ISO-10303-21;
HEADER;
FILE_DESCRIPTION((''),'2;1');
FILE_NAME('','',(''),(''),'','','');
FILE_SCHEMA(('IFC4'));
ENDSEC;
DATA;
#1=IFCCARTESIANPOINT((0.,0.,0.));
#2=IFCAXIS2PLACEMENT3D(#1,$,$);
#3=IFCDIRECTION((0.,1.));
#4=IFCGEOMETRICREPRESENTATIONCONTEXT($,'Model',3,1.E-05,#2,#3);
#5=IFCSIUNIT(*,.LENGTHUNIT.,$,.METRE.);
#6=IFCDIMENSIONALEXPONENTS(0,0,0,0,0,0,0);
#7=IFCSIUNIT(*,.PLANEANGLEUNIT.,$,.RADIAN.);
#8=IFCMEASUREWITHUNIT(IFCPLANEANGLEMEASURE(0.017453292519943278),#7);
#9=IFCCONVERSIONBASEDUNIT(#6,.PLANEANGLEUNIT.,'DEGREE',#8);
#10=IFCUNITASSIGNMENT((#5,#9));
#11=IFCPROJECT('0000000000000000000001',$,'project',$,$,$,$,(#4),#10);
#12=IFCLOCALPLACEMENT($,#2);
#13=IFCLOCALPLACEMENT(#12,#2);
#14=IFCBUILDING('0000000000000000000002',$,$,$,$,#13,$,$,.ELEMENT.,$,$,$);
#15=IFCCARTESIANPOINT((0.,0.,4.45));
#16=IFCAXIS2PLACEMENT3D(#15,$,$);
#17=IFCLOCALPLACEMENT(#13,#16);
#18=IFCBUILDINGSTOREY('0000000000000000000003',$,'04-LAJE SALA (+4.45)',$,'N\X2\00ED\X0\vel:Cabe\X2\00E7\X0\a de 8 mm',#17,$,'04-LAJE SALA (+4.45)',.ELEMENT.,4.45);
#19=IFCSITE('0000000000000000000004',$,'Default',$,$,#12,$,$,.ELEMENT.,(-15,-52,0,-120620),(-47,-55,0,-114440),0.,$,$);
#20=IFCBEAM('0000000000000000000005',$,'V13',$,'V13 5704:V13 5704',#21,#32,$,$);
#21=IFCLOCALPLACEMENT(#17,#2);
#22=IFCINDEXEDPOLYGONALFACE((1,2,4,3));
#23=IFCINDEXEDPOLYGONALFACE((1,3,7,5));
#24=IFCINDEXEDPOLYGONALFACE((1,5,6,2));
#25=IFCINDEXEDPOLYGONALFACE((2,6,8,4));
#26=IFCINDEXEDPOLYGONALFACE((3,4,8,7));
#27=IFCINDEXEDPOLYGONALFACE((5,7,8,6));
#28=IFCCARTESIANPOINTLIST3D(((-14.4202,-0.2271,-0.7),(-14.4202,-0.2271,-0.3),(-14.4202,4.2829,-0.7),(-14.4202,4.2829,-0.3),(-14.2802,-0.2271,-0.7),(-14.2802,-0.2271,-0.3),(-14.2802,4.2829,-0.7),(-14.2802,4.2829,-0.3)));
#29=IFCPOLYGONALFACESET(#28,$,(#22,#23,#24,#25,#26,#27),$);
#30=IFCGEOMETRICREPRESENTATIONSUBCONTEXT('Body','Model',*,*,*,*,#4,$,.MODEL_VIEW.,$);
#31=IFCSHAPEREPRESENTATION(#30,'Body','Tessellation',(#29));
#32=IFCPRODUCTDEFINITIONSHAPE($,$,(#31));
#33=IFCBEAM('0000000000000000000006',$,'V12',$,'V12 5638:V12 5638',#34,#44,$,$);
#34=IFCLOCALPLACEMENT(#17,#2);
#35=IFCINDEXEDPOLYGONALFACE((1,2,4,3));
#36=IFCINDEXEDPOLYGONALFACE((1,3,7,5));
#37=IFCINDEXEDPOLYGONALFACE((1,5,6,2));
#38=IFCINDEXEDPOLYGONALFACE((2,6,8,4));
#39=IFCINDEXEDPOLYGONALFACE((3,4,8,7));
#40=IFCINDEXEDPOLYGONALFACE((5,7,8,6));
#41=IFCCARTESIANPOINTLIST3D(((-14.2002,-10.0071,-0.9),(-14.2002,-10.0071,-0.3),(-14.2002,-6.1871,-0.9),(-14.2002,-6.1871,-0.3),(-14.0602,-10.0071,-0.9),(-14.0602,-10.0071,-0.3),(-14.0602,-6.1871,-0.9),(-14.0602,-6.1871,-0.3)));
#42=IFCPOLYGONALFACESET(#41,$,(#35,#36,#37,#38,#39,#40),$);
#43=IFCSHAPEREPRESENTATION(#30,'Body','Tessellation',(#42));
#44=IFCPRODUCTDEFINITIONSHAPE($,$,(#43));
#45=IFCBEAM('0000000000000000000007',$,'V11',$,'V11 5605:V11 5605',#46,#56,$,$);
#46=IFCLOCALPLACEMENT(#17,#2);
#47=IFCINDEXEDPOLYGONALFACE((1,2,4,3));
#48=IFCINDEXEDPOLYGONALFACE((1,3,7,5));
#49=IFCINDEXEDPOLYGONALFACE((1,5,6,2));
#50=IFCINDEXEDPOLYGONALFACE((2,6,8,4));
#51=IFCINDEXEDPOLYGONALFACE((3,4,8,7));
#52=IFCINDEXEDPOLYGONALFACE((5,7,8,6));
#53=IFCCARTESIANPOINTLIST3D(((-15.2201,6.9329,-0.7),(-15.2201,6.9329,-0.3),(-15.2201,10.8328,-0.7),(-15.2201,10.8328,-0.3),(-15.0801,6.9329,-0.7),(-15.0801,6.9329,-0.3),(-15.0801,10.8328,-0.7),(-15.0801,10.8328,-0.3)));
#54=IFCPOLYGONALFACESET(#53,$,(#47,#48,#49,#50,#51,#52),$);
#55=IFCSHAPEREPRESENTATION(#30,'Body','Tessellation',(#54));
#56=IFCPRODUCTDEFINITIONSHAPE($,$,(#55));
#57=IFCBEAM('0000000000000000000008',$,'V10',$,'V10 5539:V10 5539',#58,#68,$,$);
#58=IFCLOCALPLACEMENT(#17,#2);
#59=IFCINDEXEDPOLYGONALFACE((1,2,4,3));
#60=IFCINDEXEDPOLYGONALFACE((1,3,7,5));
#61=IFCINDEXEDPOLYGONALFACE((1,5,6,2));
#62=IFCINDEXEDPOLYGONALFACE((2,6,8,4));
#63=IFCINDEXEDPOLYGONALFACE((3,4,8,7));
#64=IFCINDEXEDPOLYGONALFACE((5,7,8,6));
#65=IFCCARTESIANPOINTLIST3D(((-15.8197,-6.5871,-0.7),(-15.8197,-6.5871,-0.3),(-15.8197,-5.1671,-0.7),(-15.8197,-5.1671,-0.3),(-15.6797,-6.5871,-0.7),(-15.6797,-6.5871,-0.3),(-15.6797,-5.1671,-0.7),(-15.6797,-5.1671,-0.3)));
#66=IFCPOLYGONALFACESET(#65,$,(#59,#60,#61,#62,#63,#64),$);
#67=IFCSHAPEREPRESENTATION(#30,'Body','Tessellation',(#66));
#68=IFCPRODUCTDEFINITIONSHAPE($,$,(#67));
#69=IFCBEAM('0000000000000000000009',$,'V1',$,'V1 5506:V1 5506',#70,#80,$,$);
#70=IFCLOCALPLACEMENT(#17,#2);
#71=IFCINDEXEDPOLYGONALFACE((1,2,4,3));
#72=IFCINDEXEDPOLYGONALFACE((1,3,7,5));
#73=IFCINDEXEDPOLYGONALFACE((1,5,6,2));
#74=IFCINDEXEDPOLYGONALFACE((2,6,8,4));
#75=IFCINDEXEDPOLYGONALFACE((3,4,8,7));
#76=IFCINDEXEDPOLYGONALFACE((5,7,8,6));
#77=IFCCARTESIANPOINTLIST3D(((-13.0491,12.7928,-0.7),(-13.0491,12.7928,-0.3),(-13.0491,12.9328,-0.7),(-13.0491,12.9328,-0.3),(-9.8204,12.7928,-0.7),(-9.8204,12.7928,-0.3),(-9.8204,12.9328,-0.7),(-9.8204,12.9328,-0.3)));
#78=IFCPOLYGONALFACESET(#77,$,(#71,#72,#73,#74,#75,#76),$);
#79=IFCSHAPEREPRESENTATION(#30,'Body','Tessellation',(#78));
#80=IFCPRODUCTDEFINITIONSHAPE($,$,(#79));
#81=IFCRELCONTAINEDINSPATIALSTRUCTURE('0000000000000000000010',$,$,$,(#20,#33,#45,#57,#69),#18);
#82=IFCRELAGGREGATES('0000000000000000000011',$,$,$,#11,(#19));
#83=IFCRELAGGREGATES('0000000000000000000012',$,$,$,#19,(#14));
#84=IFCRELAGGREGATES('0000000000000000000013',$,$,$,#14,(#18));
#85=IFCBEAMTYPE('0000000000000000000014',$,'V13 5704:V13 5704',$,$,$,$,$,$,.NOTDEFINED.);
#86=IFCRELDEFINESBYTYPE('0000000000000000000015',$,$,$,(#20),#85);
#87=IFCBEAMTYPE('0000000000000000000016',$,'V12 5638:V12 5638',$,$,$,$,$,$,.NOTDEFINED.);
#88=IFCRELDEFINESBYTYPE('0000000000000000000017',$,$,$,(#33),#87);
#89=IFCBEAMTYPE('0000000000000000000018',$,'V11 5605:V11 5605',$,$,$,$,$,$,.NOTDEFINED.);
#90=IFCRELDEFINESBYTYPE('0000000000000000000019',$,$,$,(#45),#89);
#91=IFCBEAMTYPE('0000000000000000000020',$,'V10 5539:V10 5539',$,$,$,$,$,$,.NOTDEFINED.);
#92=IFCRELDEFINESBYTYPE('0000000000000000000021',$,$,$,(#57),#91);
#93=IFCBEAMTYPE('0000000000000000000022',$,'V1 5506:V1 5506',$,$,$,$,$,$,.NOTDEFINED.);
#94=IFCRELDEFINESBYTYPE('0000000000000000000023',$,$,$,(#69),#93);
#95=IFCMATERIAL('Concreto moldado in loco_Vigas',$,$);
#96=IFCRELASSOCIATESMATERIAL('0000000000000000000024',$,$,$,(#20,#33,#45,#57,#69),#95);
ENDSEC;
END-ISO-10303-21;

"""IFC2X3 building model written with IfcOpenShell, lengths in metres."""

from ifc_helpers import new_model, entity, si_unit, converted_unit, direction, frame, frame_2d, origin, place, context, subcontext, project, spatial, rectangle, extrude, material, type_object, element, save


model = new_model("IFC2X3")

# Units and contexts
model_context = context("Model", 3, precision=1e-05, world=origin(), true_north=direction((0.0, 1.0)))
body_context = subcontext(model_context, "Body", "Model", "MODEL_VIEW")
ifc_project = project(units=[si_unit("LENGTHUNIT", "METRE"), converted_unit("PLANEANGLEUNIT", "DEGREE", entity("IfcPlaneAngleMeasure", 0.017453292519943278), si_unit("PLANEANGLEUNIT", "RADIAN"), dimensions=[0, 0, 0, 0, 0, 0, 0])], contexts=[model_context])

# Site, building, storey
site_placement = place(None, origin())
site = spatial("IfcSite", under=ifc_project, at=site_placement, Name="Default", CompositionType="ELEMENT", RefLatitude=(-15, -52, 0, -120620), RefLongitude=(-47, -55, 0, -114440), RefElevation=0.0)
building_placement = place(site_placement, origin())
building = spatial("IfcBuilding", under=site, at=building_placement, CompositionType="ELEMENT")
storey_placement = place(building_placement, frame((0.0, 0.0, 4.45)))
storey = spatial("IfcBuildingStorey", under=building, at=storey_placement, Name="04-LAJE SALA (+4.45)", ObjectType="Nível:Cabeça de 8 mm", LongName="04-LAJE SALA (+4.45)", CompositionType="ELEMENT", Elevation=4.45)

# Beams
ifc_material_1 = material(Name="Concreto moldado in loco_Vigas")
beam_type_1 = type_object("IfcBeamType", Name="V13 5704:V13 5704", PredefinedType="NOTDEFINED")
beam_1_placement = place(storey_placement, origin())
element("IfcBeam", 1, at=beam_1_placement, inside=storey, type_object=beam_type_1, material=ifc_material_1, Name="V13", ObjectType="V13 5704:V13 5704", context=body_context, shape_type="SweptSolid", body=[
    extrude(rectangle(XDim=0.4, YDim=4.51, at=frame_2d((0.0, 0.0), x_axis=(0.0, 1.0))), frame((-14.4202, 2.0279, -0.5), z_axis=(1.0, 0.0, 0.0), x_axis=(0.0, -1.0, 0.0)), (0.0, 0.0, 1.0), 0.14),
])
beam_type_2 = type_object("IfcBeamType", Name="V12 5638:V12 5638", PredefinedType="NOTDEFINED")
beam_2_placement = place(storey_placement, origin())
element("IfcBeam", 2, at=beam_2_placement, inside=storey, type_object=beam_type_2, material=ifc_material_1, Name="V12", ObjectType="V12 5638:V12 5638", context=body_context, shape_type="SweptSolid", body=[
    extrude(rectangle(XDim=0.6, YDim=3.82, at=frame_2d((0.0, 0.0), x_axis=(0.0, 1.0))), frame((-14.2002, -8.0971, -0.6), z_axis=(1.0, 0.0, 0.0), x_axis=(0.0, -1.0, 0.0)), (0.0, 0.0, 1.0), 0.14),
])
beam_type_3 = type_object("IfcBeamType", Name="V11 5605:V11 5605", PredefinedType="NOTDEFINED")
beam_3_placement = place(storey_placement, origin())
element("IfcBeam", 3, at=beam_3_placement, inside=storey, type_object=beam_type_3, material=ifc_material_1, Name="V11", ObjectType="V11 5605:V11 5605", context=body_context, shape_type="SweptSolid", body=[
    extrude(rectangle(XDim=0.4, YDim=3.8999, at=frame_2d((0.0, 0.0), x_axis=(0.0, 1.0))), frame((-15.2201, 8.8829, -0.5), z_axis=(1.0, 0.0, 0.0), x_axis=(0.0, -1.0, 0.0)), (0.0, 0.0, 1.0), 0.14),
])
beam_type_4 = type_object("IfcBeamType", Name="V10 5539:V10 5539", PredefinedType="NOTDEFINED")
beam_4_placement = place(storey_placement, origin())
element("IfcBeam", 4, at=beam_4_placement, inside=storey, type_object=beam_type_4, material=ifc_material_1, Name="V10", ObjectType="V10 5539:V10 5539", context=body_context, shape_type="SweptSolid", body=[
    extrude(rectangle(XDim=0.4, YDim=1.42, at=frame_2d((0.0, 0.0), x_axis=(0.0, 1.0))), frame((-15.8197, -5.8771, -0.5), z_axis=(1.0, 0.0, 0.0), x_axis=(0.0, -1.0, 0.0)), (0.0, 0.0, 1.0), 0.14),
])
beam_type_5 = type_object("IfcBeamType", Name="V1 5506:V1 5506", PredefinedType="NOTDEFINED")
beam_5_placement = place(storey_placement, origin())
element("IfcBeam", 5, at=beam_5_placement, inside=storey, type_object=beam_type_5, material=ifc_material_1, Name="V1", ObjectType="V1 5506:V1 5506", context=body_context, shape_type="SweptSolid", body=[
    extrude(rectangle(XDim=0.4, YDim=0.14, at=frame_2d((0.0, 0.0), x_axis=(1.0, 0.0))), frame((-13.0491, 12.8628, -0.5), z_axis=(1.0, 0.0, 0.0), x_axis=(0.0, 0.0, -1.0)), (0.0, 0.0, 1.0), 3.2287),
])

save(model, "model.ifc")
